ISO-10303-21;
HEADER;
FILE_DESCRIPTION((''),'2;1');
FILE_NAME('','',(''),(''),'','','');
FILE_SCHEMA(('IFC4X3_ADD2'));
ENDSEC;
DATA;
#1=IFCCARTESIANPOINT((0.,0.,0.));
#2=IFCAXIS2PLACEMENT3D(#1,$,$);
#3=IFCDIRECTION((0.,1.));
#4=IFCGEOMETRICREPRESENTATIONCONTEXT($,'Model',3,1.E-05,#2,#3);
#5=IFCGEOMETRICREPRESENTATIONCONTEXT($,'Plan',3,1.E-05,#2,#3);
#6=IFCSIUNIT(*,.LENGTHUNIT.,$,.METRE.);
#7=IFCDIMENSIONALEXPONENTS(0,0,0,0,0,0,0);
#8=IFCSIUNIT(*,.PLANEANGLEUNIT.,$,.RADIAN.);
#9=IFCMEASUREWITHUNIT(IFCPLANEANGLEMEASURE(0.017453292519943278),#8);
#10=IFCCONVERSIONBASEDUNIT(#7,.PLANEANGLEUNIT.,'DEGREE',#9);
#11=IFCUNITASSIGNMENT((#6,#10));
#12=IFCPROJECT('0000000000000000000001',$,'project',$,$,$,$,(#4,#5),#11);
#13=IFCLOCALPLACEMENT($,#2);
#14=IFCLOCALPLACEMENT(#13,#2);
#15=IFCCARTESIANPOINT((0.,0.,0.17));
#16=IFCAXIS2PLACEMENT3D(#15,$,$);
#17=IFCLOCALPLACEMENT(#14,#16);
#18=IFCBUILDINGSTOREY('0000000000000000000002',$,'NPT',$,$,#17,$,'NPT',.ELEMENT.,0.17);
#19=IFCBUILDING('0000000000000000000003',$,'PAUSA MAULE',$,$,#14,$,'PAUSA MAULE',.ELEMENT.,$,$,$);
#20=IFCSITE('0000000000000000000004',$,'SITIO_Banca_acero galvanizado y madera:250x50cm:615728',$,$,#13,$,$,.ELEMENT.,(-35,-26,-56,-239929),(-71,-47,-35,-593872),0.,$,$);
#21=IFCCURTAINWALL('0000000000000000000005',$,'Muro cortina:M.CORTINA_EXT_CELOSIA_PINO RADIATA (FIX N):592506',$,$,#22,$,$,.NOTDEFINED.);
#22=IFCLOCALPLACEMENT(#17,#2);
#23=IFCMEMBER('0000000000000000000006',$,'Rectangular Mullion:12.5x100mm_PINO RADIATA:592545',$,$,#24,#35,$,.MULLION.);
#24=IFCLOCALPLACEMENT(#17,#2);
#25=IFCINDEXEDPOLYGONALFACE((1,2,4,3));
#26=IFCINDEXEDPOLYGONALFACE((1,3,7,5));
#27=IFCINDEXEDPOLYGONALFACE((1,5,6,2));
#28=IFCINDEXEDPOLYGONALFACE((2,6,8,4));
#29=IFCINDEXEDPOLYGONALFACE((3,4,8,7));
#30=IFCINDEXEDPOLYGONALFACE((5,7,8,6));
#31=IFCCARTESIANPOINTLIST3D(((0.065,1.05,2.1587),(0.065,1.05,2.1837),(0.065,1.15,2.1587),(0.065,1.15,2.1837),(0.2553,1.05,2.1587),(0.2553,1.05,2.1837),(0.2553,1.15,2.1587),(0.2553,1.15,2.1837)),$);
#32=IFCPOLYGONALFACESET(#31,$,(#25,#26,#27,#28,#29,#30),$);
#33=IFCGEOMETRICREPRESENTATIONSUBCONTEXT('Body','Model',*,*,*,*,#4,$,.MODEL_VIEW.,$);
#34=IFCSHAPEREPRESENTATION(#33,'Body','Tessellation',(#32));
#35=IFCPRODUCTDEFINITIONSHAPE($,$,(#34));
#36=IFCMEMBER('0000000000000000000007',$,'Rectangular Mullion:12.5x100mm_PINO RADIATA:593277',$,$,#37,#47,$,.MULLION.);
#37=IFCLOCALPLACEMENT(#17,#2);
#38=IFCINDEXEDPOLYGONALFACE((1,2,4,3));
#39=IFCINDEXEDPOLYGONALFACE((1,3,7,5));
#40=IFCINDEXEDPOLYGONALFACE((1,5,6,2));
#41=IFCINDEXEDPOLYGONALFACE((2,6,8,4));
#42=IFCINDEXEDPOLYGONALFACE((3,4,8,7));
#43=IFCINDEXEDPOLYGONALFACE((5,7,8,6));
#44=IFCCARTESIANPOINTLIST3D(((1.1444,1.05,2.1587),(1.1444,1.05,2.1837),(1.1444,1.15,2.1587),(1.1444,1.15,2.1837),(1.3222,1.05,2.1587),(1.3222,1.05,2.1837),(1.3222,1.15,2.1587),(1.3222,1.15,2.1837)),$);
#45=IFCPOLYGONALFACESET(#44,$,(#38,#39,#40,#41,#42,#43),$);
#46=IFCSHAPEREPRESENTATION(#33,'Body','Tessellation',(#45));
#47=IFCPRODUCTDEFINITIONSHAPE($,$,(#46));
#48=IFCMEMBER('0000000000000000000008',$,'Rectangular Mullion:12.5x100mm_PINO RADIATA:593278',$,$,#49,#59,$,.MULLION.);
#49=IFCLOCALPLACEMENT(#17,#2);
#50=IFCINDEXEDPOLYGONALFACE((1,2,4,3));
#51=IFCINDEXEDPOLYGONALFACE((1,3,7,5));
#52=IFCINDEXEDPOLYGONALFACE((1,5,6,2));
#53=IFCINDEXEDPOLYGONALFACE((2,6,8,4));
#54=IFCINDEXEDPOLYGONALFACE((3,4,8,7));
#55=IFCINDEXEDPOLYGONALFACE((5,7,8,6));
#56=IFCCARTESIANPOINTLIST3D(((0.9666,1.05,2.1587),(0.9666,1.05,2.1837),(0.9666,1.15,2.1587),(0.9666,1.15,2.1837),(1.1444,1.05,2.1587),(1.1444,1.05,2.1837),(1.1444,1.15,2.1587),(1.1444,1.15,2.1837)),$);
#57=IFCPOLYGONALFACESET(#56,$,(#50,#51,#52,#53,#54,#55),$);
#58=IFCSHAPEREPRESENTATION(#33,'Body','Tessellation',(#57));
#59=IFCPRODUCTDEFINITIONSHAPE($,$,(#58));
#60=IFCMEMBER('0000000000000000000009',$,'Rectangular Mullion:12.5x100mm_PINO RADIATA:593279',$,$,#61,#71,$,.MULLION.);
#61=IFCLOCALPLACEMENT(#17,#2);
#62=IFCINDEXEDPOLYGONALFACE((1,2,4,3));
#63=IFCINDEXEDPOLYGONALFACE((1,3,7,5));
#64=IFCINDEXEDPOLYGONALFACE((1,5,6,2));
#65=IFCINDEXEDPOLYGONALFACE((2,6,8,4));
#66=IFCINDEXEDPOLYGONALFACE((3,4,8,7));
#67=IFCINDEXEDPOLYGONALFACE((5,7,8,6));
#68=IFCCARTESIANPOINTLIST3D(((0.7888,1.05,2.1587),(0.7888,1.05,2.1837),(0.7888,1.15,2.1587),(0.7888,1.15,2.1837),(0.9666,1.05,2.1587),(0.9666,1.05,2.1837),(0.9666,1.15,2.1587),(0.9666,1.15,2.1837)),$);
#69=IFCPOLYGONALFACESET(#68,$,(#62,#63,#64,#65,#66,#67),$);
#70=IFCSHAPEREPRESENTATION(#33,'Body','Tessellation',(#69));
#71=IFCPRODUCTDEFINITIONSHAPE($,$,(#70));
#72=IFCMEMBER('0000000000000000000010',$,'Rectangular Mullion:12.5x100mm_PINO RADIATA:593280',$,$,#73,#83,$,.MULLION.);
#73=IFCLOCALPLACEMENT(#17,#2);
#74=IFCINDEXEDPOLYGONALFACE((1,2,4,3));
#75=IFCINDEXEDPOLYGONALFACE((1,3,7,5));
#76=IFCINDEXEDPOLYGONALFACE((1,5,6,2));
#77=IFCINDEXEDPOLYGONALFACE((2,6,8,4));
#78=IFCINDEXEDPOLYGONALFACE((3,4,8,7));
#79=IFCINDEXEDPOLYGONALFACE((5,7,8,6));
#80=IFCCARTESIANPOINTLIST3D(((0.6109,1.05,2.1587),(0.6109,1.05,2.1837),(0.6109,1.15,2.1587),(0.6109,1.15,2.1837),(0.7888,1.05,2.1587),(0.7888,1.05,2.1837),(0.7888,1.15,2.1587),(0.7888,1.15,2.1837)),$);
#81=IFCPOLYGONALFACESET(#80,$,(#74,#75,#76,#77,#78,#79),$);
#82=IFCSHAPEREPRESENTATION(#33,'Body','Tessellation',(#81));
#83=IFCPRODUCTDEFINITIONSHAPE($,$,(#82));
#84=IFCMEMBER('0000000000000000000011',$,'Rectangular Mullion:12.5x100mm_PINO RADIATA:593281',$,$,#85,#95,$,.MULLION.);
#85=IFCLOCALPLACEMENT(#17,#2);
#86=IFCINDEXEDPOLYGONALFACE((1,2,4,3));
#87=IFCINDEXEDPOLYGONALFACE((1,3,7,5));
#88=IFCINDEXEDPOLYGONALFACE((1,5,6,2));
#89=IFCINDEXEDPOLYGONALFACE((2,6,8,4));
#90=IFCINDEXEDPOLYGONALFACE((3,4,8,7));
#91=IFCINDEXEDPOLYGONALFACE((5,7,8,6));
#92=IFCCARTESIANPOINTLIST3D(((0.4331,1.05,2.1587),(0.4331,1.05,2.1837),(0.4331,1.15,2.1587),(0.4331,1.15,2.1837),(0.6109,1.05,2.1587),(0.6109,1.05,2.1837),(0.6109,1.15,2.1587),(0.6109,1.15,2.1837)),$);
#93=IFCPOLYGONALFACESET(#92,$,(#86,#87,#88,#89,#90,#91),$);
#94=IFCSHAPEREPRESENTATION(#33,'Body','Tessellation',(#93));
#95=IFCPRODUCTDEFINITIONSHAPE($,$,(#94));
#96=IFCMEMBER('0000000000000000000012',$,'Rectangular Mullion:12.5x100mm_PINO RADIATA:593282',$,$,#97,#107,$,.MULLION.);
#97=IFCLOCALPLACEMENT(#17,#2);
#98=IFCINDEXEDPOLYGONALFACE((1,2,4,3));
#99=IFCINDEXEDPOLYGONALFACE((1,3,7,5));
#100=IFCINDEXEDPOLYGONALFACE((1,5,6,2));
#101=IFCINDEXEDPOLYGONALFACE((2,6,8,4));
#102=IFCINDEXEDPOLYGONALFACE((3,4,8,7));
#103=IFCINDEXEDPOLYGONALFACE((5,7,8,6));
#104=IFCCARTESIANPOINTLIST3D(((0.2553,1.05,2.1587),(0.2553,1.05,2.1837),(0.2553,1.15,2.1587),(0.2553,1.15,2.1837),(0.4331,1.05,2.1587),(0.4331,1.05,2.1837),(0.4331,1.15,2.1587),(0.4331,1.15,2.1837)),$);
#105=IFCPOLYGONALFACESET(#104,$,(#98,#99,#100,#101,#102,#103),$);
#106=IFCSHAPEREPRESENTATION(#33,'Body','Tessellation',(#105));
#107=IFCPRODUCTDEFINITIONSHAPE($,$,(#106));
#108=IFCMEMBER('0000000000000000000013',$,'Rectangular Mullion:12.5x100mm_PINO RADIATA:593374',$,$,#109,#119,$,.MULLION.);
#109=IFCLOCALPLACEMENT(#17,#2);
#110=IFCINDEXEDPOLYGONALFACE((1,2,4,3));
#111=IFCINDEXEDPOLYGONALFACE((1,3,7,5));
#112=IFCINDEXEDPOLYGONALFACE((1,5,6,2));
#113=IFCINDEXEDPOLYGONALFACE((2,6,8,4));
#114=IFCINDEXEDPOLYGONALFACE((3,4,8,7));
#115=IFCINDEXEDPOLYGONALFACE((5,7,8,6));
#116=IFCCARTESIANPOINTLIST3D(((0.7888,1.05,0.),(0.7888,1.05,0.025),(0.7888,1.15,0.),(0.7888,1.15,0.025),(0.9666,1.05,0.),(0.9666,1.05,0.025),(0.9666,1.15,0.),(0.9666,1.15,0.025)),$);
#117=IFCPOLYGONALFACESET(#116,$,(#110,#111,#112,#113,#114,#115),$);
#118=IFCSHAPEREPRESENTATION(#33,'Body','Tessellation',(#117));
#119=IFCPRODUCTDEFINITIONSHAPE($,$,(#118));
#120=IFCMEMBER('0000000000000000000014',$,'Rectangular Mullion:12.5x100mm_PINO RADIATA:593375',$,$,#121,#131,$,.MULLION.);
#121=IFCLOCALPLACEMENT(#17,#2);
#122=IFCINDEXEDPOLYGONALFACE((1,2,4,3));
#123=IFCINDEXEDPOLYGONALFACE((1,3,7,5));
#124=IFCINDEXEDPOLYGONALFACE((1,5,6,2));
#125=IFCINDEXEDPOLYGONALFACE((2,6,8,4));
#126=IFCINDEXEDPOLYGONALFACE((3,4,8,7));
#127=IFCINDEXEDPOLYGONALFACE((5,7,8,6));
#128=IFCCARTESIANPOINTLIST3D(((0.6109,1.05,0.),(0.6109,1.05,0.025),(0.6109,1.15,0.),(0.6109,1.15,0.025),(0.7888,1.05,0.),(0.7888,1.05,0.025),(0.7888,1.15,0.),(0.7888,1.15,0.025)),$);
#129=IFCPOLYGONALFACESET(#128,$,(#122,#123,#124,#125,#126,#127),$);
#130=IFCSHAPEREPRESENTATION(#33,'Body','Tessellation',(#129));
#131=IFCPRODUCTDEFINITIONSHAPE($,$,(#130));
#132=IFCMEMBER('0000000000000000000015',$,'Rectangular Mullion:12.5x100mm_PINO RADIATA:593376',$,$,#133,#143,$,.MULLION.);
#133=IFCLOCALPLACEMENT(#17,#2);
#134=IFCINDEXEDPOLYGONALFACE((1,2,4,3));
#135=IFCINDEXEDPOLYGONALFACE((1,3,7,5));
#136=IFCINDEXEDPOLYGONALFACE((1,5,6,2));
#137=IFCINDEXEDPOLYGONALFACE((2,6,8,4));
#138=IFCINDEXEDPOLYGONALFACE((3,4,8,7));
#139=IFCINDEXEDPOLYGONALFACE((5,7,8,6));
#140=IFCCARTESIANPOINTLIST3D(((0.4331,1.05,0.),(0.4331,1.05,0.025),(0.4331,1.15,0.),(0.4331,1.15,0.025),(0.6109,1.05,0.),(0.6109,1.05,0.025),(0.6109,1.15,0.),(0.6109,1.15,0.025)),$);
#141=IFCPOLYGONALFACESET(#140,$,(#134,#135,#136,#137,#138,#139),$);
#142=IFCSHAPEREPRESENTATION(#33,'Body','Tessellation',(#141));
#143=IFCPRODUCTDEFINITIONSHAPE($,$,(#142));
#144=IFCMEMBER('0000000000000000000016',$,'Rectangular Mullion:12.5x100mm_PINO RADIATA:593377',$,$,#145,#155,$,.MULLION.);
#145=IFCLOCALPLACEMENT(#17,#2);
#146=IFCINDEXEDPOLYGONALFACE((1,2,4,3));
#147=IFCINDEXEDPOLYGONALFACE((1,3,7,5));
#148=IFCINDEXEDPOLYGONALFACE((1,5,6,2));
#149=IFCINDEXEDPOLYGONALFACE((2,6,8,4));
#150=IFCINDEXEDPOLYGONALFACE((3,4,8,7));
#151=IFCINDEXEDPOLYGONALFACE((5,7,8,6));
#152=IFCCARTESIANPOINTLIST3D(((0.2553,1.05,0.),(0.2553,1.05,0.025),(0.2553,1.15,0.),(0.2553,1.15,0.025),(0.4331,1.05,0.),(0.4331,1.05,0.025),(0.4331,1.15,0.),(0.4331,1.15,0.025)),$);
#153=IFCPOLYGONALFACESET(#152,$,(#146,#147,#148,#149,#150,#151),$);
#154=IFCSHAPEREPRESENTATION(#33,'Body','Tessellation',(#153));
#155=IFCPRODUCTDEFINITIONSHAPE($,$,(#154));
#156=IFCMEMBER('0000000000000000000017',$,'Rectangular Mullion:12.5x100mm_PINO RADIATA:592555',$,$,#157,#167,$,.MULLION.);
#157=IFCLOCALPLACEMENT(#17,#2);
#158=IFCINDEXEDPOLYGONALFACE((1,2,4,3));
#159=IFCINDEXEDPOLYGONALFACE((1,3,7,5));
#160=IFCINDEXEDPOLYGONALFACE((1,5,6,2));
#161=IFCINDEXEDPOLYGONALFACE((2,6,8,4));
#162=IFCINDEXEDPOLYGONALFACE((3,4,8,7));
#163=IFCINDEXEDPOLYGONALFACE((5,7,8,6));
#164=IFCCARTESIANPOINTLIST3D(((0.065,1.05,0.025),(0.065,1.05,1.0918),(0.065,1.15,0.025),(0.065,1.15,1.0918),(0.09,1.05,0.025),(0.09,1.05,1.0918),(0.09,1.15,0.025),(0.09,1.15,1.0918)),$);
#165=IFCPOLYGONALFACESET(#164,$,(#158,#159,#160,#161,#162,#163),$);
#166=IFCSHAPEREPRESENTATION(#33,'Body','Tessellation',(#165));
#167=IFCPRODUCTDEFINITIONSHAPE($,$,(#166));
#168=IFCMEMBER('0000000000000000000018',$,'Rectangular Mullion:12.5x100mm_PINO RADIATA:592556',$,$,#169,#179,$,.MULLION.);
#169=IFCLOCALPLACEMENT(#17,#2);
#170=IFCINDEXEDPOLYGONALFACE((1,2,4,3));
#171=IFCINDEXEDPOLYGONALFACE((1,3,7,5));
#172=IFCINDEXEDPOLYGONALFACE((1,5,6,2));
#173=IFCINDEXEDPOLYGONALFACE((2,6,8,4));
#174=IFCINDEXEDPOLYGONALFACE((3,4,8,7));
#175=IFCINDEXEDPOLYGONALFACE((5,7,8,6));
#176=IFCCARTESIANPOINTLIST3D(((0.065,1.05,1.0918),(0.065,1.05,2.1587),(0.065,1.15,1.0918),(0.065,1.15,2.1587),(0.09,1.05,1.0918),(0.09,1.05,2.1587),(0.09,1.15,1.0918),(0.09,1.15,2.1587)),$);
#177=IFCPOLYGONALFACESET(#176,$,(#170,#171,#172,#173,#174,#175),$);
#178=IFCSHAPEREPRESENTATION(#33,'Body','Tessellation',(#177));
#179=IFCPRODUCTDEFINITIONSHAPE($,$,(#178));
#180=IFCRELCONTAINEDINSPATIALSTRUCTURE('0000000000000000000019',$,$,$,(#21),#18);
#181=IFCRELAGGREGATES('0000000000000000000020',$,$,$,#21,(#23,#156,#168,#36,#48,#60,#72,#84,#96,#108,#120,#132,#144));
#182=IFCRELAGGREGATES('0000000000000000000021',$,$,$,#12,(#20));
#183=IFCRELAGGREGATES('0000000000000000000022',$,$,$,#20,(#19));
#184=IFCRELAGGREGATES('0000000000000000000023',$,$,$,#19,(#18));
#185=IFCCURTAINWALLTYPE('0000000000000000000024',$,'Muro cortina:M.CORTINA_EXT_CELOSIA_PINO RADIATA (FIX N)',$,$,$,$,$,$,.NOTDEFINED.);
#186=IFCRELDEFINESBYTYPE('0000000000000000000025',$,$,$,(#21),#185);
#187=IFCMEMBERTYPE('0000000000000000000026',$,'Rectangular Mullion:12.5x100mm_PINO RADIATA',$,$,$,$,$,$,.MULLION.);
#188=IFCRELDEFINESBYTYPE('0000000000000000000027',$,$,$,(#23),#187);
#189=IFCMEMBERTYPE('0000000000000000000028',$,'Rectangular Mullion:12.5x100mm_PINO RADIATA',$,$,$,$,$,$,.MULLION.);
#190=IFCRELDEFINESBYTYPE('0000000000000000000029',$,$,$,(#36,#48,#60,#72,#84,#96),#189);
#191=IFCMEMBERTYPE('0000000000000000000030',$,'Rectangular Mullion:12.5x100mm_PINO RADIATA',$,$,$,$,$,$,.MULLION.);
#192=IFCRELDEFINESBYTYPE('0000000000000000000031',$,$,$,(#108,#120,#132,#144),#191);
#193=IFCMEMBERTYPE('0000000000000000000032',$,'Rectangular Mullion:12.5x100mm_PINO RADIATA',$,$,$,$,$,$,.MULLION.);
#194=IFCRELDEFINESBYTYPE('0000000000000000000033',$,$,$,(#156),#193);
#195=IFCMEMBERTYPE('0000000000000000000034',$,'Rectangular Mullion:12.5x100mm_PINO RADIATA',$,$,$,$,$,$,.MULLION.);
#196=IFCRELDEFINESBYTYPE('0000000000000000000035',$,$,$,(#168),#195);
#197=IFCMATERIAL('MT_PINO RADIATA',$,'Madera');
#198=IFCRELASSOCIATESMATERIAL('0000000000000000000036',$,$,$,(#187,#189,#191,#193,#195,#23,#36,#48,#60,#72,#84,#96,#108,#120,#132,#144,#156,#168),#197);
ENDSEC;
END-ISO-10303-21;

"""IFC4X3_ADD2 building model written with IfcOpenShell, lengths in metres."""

from ifc_helpers import new_model, entity, si_unit, converted_unit, direction, frame, frame_2d, origin, origin_2d_with_axis, place, context, subcontext, project, spatial, rectangle, extrude, source, transform, mapped, material, material_profile, profile_set, profile_usage, type_object, type_shapes, element, aggregate, save


model = new_model("IFC4X3_ADD2")

# Units and contexts
model_context = context("Model", 3, precision=1e-05, world=origin(), true_north=direction((0.0, 1.0)))
plan_context = context("Plan", 3, precision=1e-05, world=origin(), true_north=direction((0.0, 1.0)))
body_context = subcontext(model_context, "Body", "Model", "MODEL_VIEW")
ifc_project = project(units=[si_unit("LENGTHUNIT", "METRE"), converted_unit("PLANEANGLEUNIT", "DEGREE", entity("IfcPlaneAngleMeasure", 0.017453292519943278), si_unit("PLANEANGLEUNIT", "RADIAN"), dimensions=[0, 0, 0, 0, 0, 0, 0])], contexts=[model_context, plan_context])

# Site, building, storey
site_placement = place(None, origin())
site = spatial("IfcSite", under=ifc_project, at=site_placement, Name="SITIO_Banca_acero galvanizado y madera:250x50cm:615728", CompositionType="ELEMENT", RefLatitude=(-35, -26, -56, -239929), RefLongitude=(-71, -47, -35, -593872), RefElevation=0.0)
building_placement = place(site_placement, origin())
building = spatial("IfcBuilding", under=site, at=building_placement, Name="PAUSA MAULE", LongName="PAUSA MAULE", CompositionType="ELEMENT")
storey_placement = place(building_placement, frame((0.0, 0.0, 0.17)))
storey = spatial("IfcBuildingStorey", under=building, at=storey_placement, Name="NPT", LongName="NPT", CompositionType="ELEMENT", Elevation=0.17)

# Curtain wall, members
curtain_wall_type = type_object("IfcCurtainWallType", Name="Muro cortina:M.CORTINA_EXT_CELOSIA_PINO RADIATA (FIX N)", PredefinedType="NOTDEFINED")
curtain_wall_placement = place(storey_placement, frame((0.0, 0.0, -0.17)))
curtain_wall = element("IfcCurtainWall", 1, at=curtain_wall_placement, inside=storey, type_object=curtain_wall_type, Name="Muro cortina:M.CORTINA_EXT_CELOSIA_PINO RADIATA (FIX N):592506", PredefinedType="NOTDEFINED")
ifc_material_1 = material(Name="MT_PINO RADIATA", Category="Madera")
ifc_material_profile = material_profile(ifc_material_1, rectangle(XDim=0.025, YDim=0.1, at=frame_2d((0.0, 0.0), x_axis=(1.0, 0.0))), Name="12.5x100mm_PINO RADIATA")
ifc_profile_set = profile_set([ifc_material_profile], Name="12.5x100mm_PINO RADIATA")
ifc_profile_usage = profile_usage(ifc_profile_set)
member_type_1 = type_object("IfcMemberType", Name="Rectangular Mullion:12.5x100mm_PINO RADIATA", PredefinedType="MULLION", material=ifc_profile_set)
shared_shape_1 = source(origin(), body_context, "Body", "SweptSolid", [
    extrude(rectangle(XDim=0.025, YDim=0.1, at=frame_2d((0.0, 0.0), x_axis=(1.0, 0.0))), frame((-0.0125, 0.0, -0.1903), z_axis=(0.0, 0.0, 1.0), x_axis=(-1.0, 0.0, 0.0)), (0.0, 0.0, 1.0), 0.1903),
])
type_shapes(member_type_1, [shared_shape_1])
member_1_placement = place(curtain_wall_placement, frame((0.065, 1.1, 2.3537), z_axis=(-1.0, 0.0, 0.0), x_axis=(0.0, 0.0, 1.0)))
member_1 = element("IfcMember", 2, at=member_1_placement, type_object=member_type_1, material=ifc_profile_usage, Name="Rectangular Mullion:12.5x100mm_PINO RADIATA:592545", PredefinedType="MULLION", context=body_context, shape_type="MappedRepresentation", body=[
    mapped(shared_shape_1, transform((0.0, 0.0, 0.0), scale=1.0)),
])
member_type_2 = type_object("IfcMemberType", Name="Rectangular Mullion:12.5x100mm_PINO RADIATA", PredefinedType="MULLION", material=ifc_profile_set)
shared_shape_2 = source(origin(), body_context, "Body", "SweptSolid", [
    extrude(rectangle(XDim=0.025, YDim=0.1, at=frame_2d((0.0, 0.0), x_axis=(1.0, 0.0))), frame((-0.0125, 0.0, -0.1778), z_axis=(0.0, 0.0, 1.0), x_axis=(-1.0, 0.0, 0.0)), (0.0, 0.0, 1.0), 0.1778),
])
type_shapes(member_type_2, [shared_shape_2])
member_2_placement = place(curtain_wall_placement, frame((1.1444, 1.1, 2.3537), z_axis=(-1.0, 0.0, 0.0), x_axis=(0.0, 0.0, 1.0)))
member_2 = element("IfcMember", 3, at=member_2_placement, type_object=member_type_2, material=ifc_profile_usage, Name="Rectangular Mullion:12.5x100mm_PINO RADIATA:593277", PredefinedType="MULLION", context=body_context, shape_type="MappedRepresentation", body=[
    mapped(shared_shape_2, transform((0.0, 0.0, 0.0), scale=1.0)),
])
member_3_placement = place(curtain_wall_placement, frame((0.9666, 1.1, 2.3537), z_axis=(-1.0, 0.0, 0.0), x_axis=(0.0, 0.0, 1.0)))
member_3 = element("IfcMember", 4, at=member_3_placement, type_object=member_type_2, material=ifc_profile_usage, Name="Rectangular Mullion:12.5x100mm_PINO RADIATA:593278", PredefinedType="MULLION", context=body_context, shape_type="MappedRepresentation", body=[
    mapped(shared_shape_2, transform((0.0, 0.0, 0.0), scale=1.0)),
])
member_4_placement = place(curtain_wall_placement, frame((0.7888, 1.1, 2.3537), z_axis=(-1.0, 0.0, 0.0), x_axis=(0.0, 0.0, 1.0)))
member_4 = element("IfcMember", 5, at=member_4_placement, type_object=member_type_2, material=ifc_profile_usage, Name="Rectangular Mullion:12.5x100mm_PINO RADIATA:593279", PredefinedType="MULLION", context=body_context, shape_type="MappedRepresentation", body=[
    mapped(shared_shape_2, transform((0.0, 0.0, 0.0), scale=1.0)),
])
member_5_placement = place(curtain_wall_placement, frame((0.6109, 1.1, 2.3537), z_axis=(-1.0, 0.0, 0.0), x_axis=(0.0, 0.0, 1.0)))
member_5 = element("IfcMember", 6, at=member_5_placement, type_object=member_type_2, material=ifc_profile_usage, Name="Rectangular Mullion:12.5x100mm_PINO RADIATA:593280", PredefinedType="MULLION", context=body_context, shape_type="MappedRepresentation", body=[
    mapped(shared_shape_2, transform((0.0, 0.0, 0.0), scale=1.0)),
])
member_6_placement = place(curtain_wall_placement, frame((0.4331, 1.1, 2.3537), z_axis=(-1.0, 0.0, 0.0), x_axis=(0.0, 0.0, 1.0)))
member_6 = element("IfcMember", 7, at=member_6_placement, type_object=member_type_2, material=ifc_profile_usage, Name="Rectangular Mullion:12.5x100mm_PINO RADIATA:593281", PredefinedType="MULLION", context=body_context, shape_type="MappedRepresentation", body=[
    mapped(shared_shape_2, transform((0.0, 0.0, 0.0), scale=1.0)),
])
member_7_placement = place(curtain_wall_placement, frame((0.2553, 1.1, 2.3537), z_axis=(-1.0, 0.0, 0.0), x_axis=(0.0, 0.0, 1.0)))
member_7 = element("IfcMember", 8, at=member_7_placement, type_object=member_type_2, material=ifc_profile_usage, Name="Rectangular Mullion:12.5x100mm_PINO RADIATA:593282", PredefinedType="MULLION", context=body_context, shape_type="MappedRepresentation", body=[
    mapped(shared_shape_2, transform((0.0, 0.0, 0.0), scale=1.0)),
])
member_type_3 = type_object("IfcMemberType", Name="Rectangular Mullion:12.5x100mm_PINO RADIATA", PredefinedType="MULLION", material=ifc_profile_set)
shared_shape_3 = source(origin(), body_context, "Body", "SweptSolid", [
    extrude(rectangle(XDim=0.025, YDim=0.1, at=frame_2d((0.0, 0.0), x_axis=(1.0, 0.0))), frame((-0.0125, 0.0, -0.1778), z_axis=(0.0, 0.0, 1.0), x_axis=(-1.0, 0.0, 0.0)), (0.0, 0.0, 1.0), 0.1778),
])
type_shapes(member_type_3, [shared_shape_3])
member_8_placement = place(curtain_wall_placement, frame((0.9666, 1.1, 0.17), z_axis=(1.0, 0.0, 0.0), x_axis=(0.0, 0.0, -1.0)))
member_8 = element("IfcMember", 9, at=member_8_placement, type_object=member_type_3, material=ifc_profile_usage, Name="Rectangular Mullion:12.5x100mm_PINO RADIATA:593374", PredefinedType="MULLION", context=body_context, shape_type="MappedRepresentation", body=[
    mapped(shared_shape_3, transform((0.0, 0.0, 0.0), scale=1.0)),
])
member_9_placement = place(curtain_wall_placement, frame((0.7888, 1.1, 0.17), z_axis=(1.0, 0.0, 0.0), x_axis=(0.0, 0.0, -1.0)))
member_9 = element("IfcMember", 10, at=member_9_placement, type_object=member_type_3, material=ifc_profile_usage, Name="Rectangular Mullion:12.5x100mm_PINO RADIATA:593375", PredefinedType="MULLION", context=body_context, shape_type="MappedRepresentation", body=[
    mapped(shared_shape_3, transform((0.0, 0.0, 0.0), scale=1.0)),
])
member_10_placement = place(curtain_wall_placement, frame((0.6109, 1.1, 0.17), z_axis=(1.0, 0.0, 0.0), x_axis=(0.0, 0.0, -1.0)))
member_10 = element("IfcMember", 11, at=member_10_placement, type_object=member_type_3, material=ifc_profile_usage, Name="Rectangular Mullion:12.5x100mm_PINO RADIATA:593376", PredefinedType="MULLION", context=body_context, shape_type="MappedRepresentation", body=[
    mapped(shared_shape_3, transform((0.0, 0.0, 0.0), scale=1.0)),
])
member_11_placement = place(curtain_wall_placement, frame((0.4331, 1.1, 0.17), z_axis=(1.0, 0.0, 0.0), x_axis=(0.0, 0.0, -1.0)))
member_11 = element("IfcMember", 12, at=member_11_placement, type_object=member_type_3, material=ifc_profile_usage, Name="Rectangular Mullion:12.5x100mm_PINO RADIATA:593377", PredefinedType="MULLION", context=body_context, shape_type="MappedRepresentation", body=[
    mapped(shared_shape_3, transform((0.0, 0.0, 0.0), scale=1.0)),
])
member_type_4 = type_object("IfcMemberType", Name="Rectangular Mullion:12.5x100mm_PINO RADIATA", PredefinedType="MULLION", material=ifc_profile_set)
shared_shape_4 = source(origin(), body_context, "Body", "SweptSolid", [
    extrude(rectangle(XDim=0.025, YDim=0.1, at=origin_2d_with_axis()), frame((-0.0125, 0.0, -1.0668), z_axis=(0.0, 0.0, 1.0), x_axis=(-1.0, 0.0, 0.0)), (0.0, 0.0, 1.0), 1.0668),
])
type_shapes(member_type_4, [shared_shape_4])
member_12_placement = place(curtain_wall_placement, frame((0.065, 1.1, 0.195), z_axis=(0.0, 0.0, -1.0), x_axis=(-1.0, 0.0, 0.0)))
member_12 = element("IfcMember", 13, at=member_12_placement, type_object=member_type_4, material=ifc_profile_usage, Name="Rectangular Mullion:12.5x100mm_PINO RADIATA:592555", PredefinedType="MULLION", context=body_context, shape_type="MappedRepresentation", body=[
    mapped(shared_shape_4, transform((0.0, 0.0, 0.0), scale=1.0)),
])
member_type_5 = type_object("IfcMemberType", Name="Rectangular Mullion:12.5x100mm_PINO RADIATA", PredefinedType="MULLION", material=ifc_profile_set)
shared_shape_5 = source(origin(), body_context, "Body", "SweptSolid", [
    extrude(rectangle(XDim=0.025, YDim=0.1, at=frame_2d((0.0, 0.0), x_axis=(1.0, 0.0))), frame((-0.0125, 0.0, -1.0668), z_axis=(0.0, 0.0, 1.0), x_axis=(-1.0, 0.0, 0.0)), (0.0, 0.0, 1.0), 1.0668),
])
type_shapes(member_type_5, [shared_shape_5])
member_13_placement = place(curtain_wall_placement, frame((0.065, 1.1, 1.2618), z_axis=(0.0, 0.0, -1.0), x_axis=(-1.0, 0.0, 0.0)))
member_13 = element("IfcMember", 14, at=member_13_placement, type_object=member_type_5, material=ifc_profile_usage, Name="Rectangular Mullion:12.5x100mm_PINO RADIATA:592556", PredefinedType="MULLION", context=body_context, shape_type="MappedRepresentation", body=[
    mapped(shared_shape_5, transform((0.0, 0.0, 0.0), scale=1.0)),
])
aggregate(curtain_wall, [member_1, member_12, member_13, member_2, member_3, member_4, member_5, member_6, member_7, member_8, member_9, member_10, member_11])

save(model, "model.ifc")
